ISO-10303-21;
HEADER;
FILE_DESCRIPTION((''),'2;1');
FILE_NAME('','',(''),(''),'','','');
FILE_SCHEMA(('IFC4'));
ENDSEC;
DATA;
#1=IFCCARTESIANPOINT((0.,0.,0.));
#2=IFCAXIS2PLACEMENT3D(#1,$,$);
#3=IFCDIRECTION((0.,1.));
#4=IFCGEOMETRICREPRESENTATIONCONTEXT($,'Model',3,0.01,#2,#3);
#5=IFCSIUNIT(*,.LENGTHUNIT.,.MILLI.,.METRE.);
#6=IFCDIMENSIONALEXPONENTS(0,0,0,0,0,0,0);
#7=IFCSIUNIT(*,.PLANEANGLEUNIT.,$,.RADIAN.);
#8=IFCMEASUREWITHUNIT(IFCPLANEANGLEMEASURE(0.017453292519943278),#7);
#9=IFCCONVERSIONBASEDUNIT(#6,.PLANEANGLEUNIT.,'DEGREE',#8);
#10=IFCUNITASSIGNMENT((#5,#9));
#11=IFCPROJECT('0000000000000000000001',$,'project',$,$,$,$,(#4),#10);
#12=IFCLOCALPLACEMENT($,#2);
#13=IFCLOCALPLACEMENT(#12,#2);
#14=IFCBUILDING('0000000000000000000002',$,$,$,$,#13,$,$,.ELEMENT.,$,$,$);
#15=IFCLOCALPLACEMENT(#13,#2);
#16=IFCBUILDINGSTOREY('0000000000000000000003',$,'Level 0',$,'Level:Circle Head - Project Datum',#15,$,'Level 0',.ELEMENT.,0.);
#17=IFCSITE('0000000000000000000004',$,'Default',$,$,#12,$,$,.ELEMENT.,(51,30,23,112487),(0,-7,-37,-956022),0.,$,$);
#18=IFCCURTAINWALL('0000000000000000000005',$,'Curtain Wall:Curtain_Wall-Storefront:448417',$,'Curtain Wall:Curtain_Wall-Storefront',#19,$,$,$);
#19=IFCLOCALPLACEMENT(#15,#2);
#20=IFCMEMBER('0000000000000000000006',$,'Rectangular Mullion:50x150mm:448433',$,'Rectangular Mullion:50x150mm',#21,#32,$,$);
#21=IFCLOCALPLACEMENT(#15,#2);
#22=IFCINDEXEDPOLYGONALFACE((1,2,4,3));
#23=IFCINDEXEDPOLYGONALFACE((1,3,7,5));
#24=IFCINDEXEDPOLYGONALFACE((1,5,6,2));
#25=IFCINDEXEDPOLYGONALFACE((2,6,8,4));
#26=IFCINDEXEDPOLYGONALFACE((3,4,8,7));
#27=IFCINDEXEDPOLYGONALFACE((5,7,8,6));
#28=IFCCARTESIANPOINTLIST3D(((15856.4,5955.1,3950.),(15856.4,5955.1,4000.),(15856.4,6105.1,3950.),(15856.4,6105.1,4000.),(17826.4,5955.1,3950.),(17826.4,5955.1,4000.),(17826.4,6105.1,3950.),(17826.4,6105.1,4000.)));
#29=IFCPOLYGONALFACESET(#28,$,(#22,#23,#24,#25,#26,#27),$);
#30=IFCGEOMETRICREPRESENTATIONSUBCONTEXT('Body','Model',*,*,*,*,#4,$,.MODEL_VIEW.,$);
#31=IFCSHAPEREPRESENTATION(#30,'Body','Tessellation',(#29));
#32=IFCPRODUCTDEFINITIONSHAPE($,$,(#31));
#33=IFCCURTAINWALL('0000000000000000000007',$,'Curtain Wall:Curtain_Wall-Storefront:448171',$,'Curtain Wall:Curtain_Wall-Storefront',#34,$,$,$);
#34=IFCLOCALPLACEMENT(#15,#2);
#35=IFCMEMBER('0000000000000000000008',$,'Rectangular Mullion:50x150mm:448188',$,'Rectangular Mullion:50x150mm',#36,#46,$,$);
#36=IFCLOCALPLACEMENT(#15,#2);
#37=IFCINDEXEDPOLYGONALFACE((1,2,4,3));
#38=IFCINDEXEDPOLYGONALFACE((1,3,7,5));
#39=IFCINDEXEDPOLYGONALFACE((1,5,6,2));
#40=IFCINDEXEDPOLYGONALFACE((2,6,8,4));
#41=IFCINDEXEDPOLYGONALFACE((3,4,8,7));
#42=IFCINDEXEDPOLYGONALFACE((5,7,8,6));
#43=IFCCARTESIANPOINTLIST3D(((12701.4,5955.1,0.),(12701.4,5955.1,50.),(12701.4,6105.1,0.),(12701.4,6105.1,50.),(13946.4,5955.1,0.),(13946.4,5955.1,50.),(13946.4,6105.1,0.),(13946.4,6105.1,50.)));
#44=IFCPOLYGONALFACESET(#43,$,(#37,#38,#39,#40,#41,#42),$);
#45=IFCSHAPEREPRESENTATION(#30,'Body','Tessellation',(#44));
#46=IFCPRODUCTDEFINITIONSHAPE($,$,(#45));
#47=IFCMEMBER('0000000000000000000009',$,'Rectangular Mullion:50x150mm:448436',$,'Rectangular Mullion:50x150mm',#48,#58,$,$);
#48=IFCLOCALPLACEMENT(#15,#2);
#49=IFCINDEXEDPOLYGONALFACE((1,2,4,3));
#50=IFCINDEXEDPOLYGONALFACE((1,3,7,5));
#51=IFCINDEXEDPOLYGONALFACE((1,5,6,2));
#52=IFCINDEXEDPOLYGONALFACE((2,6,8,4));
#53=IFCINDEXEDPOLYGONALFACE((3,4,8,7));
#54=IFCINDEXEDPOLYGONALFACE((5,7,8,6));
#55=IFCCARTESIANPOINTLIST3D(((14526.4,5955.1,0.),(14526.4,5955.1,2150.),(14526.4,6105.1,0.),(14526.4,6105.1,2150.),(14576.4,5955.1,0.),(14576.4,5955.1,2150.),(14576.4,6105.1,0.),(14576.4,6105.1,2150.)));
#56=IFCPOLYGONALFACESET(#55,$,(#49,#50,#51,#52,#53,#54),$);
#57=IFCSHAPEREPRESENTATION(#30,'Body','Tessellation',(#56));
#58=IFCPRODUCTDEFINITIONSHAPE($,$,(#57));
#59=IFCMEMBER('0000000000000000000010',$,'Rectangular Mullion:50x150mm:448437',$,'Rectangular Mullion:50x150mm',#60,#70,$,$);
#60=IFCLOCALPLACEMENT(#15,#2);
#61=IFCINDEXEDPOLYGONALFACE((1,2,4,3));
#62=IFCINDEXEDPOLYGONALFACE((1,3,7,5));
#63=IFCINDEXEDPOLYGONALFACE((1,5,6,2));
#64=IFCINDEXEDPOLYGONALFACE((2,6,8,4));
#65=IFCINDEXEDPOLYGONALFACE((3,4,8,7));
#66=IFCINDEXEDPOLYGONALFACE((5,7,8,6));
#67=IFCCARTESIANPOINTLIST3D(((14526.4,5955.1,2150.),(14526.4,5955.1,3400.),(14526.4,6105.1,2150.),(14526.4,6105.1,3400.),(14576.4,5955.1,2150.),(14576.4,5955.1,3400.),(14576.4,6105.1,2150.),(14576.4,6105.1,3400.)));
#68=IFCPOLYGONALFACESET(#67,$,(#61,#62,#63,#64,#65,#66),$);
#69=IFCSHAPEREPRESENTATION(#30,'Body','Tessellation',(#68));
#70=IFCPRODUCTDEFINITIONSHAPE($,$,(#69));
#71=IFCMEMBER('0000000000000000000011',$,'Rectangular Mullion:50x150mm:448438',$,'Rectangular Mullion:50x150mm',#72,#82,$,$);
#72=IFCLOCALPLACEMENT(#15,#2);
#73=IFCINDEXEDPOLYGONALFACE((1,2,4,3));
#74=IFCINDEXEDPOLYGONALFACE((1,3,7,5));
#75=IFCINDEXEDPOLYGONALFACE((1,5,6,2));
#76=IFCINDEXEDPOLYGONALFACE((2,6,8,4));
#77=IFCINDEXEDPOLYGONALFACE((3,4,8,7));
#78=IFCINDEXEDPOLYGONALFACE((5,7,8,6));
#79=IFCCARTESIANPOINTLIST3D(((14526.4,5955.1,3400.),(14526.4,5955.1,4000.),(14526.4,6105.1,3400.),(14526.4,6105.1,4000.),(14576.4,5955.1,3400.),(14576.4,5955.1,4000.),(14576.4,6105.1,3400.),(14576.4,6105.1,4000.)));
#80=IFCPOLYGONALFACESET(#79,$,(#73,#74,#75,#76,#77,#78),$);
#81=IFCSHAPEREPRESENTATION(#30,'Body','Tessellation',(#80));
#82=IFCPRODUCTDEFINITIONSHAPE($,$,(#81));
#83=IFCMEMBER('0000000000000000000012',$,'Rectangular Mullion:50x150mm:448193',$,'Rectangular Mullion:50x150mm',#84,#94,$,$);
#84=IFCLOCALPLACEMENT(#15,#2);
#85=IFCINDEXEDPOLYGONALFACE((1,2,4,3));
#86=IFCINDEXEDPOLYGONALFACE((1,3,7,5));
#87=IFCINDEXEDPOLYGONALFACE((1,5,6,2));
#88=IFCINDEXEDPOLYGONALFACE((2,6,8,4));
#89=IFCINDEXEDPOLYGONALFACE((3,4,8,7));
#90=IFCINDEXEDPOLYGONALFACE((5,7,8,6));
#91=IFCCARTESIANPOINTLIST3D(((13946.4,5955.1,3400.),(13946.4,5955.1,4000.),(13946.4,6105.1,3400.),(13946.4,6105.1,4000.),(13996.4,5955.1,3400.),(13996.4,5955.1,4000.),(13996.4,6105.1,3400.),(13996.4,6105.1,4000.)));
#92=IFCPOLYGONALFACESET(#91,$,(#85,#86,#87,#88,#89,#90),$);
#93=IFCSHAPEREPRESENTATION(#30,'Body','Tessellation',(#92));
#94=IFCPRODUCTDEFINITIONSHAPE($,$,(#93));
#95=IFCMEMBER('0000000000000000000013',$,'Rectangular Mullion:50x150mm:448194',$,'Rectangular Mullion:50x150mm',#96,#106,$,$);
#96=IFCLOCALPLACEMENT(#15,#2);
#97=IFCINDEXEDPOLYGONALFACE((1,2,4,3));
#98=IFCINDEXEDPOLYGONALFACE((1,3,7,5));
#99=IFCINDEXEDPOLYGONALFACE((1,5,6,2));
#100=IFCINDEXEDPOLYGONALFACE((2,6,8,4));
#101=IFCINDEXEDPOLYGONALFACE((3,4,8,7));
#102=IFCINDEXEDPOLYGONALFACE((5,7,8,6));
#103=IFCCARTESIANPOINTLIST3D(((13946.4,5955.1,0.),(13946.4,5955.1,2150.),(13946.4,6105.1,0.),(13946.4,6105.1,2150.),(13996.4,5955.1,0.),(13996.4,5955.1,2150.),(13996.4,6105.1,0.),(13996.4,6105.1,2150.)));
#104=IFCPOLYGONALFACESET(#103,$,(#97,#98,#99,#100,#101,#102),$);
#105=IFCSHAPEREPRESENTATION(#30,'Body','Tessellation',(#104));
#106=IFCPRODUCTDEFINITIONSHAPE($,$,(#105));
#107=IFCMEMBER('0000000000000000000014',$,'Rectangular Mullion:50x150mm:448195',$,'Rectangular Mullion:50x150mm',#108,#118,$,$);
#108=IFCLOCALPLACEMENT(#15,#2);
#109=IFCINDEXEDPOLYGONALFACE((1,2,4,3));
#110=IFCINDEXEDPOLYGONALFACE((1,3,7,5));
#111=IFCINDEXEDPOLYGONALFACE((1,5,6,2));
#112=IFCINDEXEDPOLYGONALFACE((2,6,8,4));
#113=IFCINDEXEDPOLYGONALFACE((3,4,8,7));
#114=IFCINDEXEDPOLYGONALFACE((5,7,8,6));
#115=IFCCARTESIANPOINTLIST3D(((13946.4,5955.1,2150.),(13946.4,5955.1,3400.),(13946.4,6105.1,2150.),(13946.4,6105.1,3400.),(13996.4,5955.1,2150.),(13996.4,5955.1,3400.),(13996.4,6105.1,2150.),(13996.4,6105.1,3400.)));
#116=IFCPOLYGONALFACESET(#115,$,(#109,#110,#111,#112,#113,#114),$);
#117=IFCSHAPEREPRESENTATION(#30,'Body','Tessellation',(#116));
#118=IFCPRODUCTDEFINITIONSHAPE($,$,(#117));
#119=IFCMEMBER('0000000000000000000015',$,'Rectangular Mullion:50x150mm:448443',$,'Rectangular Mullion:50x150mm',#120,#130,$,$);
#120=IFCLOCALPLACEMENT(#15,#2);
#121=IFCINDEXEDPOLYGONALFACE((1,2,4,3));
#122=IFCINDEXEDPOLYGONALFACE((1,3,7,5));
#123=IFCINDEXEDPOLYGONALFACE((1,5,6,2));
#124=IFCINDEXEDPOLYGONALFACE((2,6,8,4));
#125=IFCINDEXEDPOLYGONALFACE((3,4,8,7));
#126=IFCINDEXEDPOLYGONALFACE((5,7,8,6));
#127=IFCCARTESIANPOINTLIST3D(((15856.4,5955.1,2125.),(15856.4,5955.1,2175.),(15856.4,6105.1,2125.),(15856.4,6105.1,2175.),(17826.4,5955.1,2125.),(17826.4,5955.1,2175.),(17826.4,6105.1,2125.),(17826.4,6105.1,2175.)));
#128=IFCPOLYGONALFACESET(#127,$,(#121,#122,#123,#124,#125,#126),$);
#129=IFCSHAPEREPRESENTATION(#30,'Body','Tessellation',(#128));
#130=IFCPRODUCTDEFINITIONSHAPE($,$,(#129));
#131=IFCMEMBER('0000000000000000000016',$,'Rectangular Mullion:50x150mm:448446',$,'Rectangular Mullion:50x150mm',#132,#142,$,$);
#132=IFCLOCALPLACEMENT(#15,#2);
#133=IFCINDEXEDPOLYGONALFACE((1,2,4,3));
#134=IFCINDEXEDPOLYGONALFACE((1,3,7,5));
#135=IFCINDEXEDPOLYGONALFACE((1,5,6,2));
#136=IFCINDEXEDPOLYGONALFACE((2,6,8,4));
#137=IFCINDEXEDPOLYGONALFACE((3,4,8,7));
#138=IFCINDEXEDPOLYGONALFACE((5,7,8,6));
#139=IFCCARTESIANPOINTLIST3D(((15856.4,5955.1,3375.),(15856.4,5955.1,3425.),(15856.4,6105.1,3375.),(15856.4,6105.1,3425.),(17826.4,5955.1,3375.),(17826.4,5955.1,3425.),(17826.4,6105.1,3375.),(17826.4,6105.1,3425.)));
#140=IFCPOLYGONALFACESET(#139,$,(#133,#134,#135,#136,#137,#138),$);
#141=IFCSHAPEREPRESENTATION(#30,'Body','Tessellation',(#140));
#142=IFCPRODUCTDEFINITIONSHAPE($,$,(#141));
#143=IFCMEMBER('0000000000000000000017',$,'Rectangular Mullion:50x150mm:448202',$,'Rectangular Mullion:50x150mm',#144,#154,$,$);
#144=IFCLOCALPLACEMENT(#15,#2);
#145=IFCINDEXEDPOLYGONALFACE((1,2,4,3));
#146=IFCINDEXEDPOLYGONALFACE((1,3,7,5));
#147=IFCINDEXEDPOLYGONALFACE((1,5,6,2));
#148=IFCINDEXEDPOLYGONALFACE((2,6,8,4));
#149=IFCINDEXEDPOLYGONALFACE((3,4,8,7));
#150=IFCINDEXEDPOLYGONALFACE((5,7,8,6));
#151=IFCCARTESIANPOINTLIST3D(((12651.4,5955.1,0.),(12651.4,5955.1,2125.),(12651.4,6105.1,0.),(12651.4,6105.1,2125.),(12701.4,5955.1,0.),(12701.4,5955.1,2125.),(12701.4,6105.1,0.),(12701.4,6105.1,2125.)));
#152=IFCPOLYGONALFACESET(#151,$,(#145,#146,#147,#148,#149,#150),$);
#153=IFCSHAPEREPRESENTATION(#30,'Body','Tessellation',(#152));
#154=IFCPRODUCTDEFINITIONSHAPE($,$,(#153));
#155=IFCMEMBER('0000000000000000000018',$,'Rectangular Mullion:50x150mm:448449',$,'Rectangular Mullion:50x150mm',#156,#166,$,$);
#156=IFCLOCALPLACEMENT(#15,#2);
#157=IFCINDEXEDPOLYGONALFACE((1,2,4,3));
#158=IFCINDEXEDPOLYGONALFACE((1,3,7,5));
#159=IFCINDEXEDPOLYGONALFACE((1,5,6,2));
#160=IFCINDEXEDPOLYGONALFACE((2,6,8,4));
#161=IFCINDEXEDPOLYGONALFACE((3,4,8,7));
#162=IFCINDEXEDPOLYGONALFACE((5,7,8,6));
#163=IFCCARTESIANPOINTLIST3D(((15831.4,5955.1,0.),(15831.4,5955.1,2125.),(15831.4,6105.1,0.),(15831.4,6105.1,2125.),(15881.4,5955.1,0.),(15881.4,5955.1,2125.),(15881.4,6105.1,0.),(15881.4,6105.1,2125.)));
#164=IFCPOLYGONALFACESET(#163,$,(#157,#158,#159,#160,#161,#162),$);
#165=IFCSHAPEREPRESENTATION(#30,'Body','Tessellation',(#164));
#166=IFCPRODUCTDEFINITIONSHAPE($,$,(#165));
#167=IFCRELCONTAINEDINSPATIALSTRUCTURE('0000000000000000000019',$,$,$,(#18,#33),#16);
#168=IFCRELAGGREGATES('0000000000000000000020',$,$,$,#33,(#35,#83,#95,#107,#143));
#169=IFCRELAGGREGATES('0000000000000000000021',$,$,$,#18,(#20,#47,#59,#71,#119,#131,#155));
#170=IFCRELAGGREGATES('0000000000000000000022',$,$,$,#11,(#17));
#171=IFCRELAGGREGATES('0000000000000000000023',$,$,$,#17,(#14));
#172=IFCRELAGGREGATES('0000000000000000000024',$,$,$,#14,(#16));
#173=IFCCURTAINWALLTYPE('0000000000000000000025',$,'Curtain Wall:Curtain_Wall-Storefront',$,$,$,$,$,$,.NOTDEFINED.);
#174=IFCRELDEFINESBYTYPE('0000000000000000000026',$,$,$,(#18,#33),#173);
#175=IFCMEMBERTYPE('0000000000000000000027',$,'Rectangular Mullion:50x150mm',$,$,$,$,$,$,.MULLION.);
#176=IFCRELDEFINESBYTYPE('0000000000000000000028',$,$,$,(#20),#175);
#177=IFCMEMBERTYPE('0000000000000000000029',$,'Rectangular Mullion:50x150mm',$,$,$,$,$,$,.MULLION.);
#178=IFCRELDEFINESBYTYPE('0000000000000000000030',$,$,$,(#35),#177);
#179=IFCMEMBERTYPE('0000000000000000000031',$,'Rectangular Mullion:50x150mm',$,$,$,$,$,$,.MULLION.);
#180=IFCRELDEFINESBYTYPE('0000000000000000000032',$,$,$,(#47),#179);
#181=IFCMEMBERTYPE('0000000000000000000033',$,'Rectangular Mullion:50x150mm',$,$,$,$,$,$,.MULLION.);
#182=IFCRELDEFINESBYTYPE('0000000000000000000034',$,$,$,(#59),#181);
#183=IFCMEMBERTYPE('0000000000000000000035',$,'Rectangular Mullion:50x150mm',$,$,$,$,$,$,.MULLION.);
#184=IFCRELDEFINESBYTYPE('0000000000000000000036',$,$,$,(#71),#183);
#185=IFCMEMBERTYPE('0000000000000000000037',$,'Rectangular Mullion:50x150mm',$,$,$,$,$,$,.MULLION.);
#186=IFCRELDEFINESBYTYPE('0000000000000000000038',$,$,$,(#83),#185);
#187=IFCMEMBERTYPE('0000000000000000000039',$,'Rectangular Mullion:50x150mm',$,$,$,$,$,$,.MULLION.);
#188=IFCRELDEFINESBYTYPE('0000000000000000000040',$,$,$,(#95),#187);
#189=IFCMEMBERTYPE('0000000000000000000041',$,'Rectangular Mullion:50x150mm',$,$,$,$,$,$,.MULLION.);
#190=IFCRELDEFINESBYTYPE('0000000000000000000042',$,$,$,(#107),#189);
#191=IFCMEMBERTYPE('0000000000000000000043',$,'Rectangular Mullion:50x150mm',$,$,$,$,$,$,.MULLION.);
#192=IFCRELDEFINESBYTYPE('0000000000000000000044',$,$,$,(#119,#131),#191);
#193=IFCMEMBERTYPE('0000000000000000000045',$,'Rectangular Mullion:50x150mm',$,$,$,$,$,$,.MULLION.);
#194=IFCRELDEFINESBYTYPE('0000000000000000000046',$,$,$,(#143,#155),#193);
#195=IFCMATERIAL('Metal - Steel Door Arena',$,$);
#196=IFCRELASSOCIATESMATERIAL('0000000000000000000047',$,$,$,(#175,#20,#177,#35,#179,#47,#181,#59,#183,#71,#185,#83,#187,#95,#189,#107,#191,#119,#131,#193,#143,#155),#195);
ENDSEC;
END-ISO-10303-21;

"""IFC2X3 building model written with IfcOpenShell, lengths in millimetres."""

from ifc_helpers import new_model, entity, si_unit, converted_unit, direction, frame, origin, origin_2d_with_axis, place, context, subcontext, project, spatial, rectangle, extrude, source, transform, mapped, material, type_object, type_shapes, element, aggregate, save


model = new_model("IFC2X3")

# Units and contexts
model_context = context("Model", 3, precision=0.01, world=origin(), true_north=direction((0.0, 1.0)))
body_context = subcontext(model_context, "Body", "Model", "MODEL_VIEW")
ifc_project = project(units=[si_unit("LENGTHUNIT", "METRE", prefix="MILLI"), converted_unit("PLANEANGLEUNIT", "DEGREE", entity("IfcPlaneAngleMeasure", 0.017453292519943278), si_unit("PLANEANGLEUNIT", "RADIAN"), dimensions=[0, 0, 0, 0, 0, 0, 0])], contexts=[model_context])

# Site, building, storey
site_placement = place(None, origin())
site = spatial("IfcSite", under=ifc_project, at=site_placement, Name="Default", CompositionType="ELEMENT", RefLatitude=(51, 30, 23, 112487), RefLongitude=(0, -7, -37, -956022), RefElevation=0.0)
building_placement = place(site_placement, origin())
building = spatial("IfcBuilding", under=site, at=building_placement, CompositionType="ELEMENT")
storey_placement = place(building_placement, origin())
storey = spatial("IfcBuildingStorey", under=building, at=storey_placement, Name="Level 0", ObjectType="Level:Circle Head - Project Datum", LongName="Level 0", CompositionType="ELEMENT", Elevation=0.0)

# Curtain walls, members
curtain_wall_type = type_object("IfcCurtainWallType", Name="Curtain Wall:Curtain_Wall-Storefront", PredefinedType="NOTDEFINED")
curtain_wall_1_placement = place(storey_placement, origin())
curtain_wall_1 = element("IfcCurtainWall", 1, at=curtain_wall_1_placement, inside=storey, type_object=curtain_wall_type, Name="Curtain Wall:Curtain_Wall-Storefront:448417", ObjectType="Curtain Wall:Curtain_Wall-Storefront")
ifc_material_1 = material(Name="Metal - Steel Door Arena")
member_type_1 = type_object("IfcMemberType", Name="Rectangular Mullion:50x150mm", PredefinedType="MULLION", material=ifc_material_1)
shared_shape_1 = source(origin(), body_context, "Body", "SweptSolid", [
    extrude(rectangle(XDim=50.0, YDim=150.0, at=origin_2d_with_axis()), frame((-25.0, 0.0, -1970.0), z_axis=(0.0, 0.0, 1.0), x_axis=(-1.0, 0.0, 0.0)), (0.0, 0.0, 1.0), 1970.0),
])
type_shapes(member_type_1, [shared_shape_1])
member_1_placement = place(curtain_wall_1_placement, frame((15856.4, 6030.1, 4000.0), z_axis=(-1.0, 0.0, 0.0), x_axis=(0.0, 0.0, 1.0)))
member_1 = element("IfcMember", 2, at=member_1_placement, type_object=member_type_1, material=ifc_material_1, Name="Rectangular Mullion:50x150mm:448433", ObjectType="Rectangular Mullion:50x150mm", context=body_context, shape_type="MappedRepresentation", body=[
    mapped(shared_shape_1, transform((0.0, 0.0, 0.0), scale=1.0)),
])
curtain_wall_2_placement = place(storey_placement, origin())
curtain_wall_2 = element("IfcCurtainWall", 3, at=curtain_wall_2_placement, inside=storey, type_object=curtain_wall_type, Name="Curtain Wall:Curtain_Wall-Storefront:448171", ObjectType="Curtain Wall:Curtain_Wall-Storefront")
member_type_2 = type_object("IfcMemberType", Name="Rectangular Mullion:50x150mm", PredefinedType="MULLION", material=ifc_material_1)
shared_shape_2 = source(origin(), body_context, "Body", "SweptSolid", [
    extrude(rectangle(XDim=50.0, YDim=150.0, at=origin_2d_with_axis()), frame((-25.0, 0.0, -1245.0), z_axis=(0.0, 0.0, 1.0), x_axis=(-1.0, 0.0, 0.0)), (0.0, 0.0, 1.0), 1245.0),
])
type_shapes(member_type_2, [shared_shape_2])
member_2_placement = place(curtain_wall_2_placement, frame((13946.4, 6030.1, 0.0), z_axis=(1.0, 0.0, 0.0), x_axis=(0.0, 0.0, -1.0)))
member_2 = element("IfcMember", 4, at=member_2_placement, type_object=member_type_2, material=ifc_material_1, Name="Rectangular Mullion:50x150mm:448188", ObjectType="Rectangular Mullion:50x150mm", context=body_context, shape_type="MappedRepresentation", body=[
    mapped(shared_shape_2, transform((0.0, 0.0, 0.0), scale=1.0)),
])

# Members
member_type_3 = type_object("IfcMemberType", Name="Rectangular Mullion:50x150mm", PredefinedType="MULLION", material=ifc_material_1)
shared_shape_3 = source(origin(), body_context, "Body", "SweptSolid", [
    extrude(rectangle(XDim=50.0, YDim=150.0, at=origin_2d_with_axis()), frame((-25.0, 0.0, -2150.0), z_axis=(0.0, 0.0, 1.0), x_axis=(-1.0, 0.0, 0.0)), (0.0, 0.0, 1.0), 2150.0),
])
type_shapes(member_type_3, [shared_shape_3])
member_3_placement = place(curtain_wall_1_placement, frame((14526.4, 6030.1, 0.0), z_axis=(0.0, 0.0, -1.0), x_axis=(-1.0, 0.0, 0.0)))
member_3 = element("IfcMember", 5, at=member_3_placement, type_object=member_type_3, material=ifc_material_1, Name="Rectangular Mullion:50x150mm:448436", ObjectType="Rectangular Mullion:50x150mm", context=body_context, shape_type="MappedRepresentation", body=[
    mapped(shared_shape_3, transform((0.0, 0.0, 0.0), scale=1.0)),
])
member_type_4 = type_object("IfcMemberType", Name="Rectangular Mullion:50x150mm", PredefinedType="MULLION", material=ifc_material_1)
shared_shape_4 = source(origin(), body_context, "Body", "SweptSolid", [
    extrude(rectangle(XDim=50.0, YDim=150.0, at=origin_2d_with_axis()), frame((-25.0, 0.0, -1250.0), z_axis=(0.0, 0.0, 1.0), x_axis=(-1.0, 0.0, 0.0)), (0.0, 0.0, 1.0), 1250.0),
])
type_shapes(member_type_4, [shared_shape_4])
member_4_placement = place(curtain_wall_1_placement, frame((14526.4, 6030.1, 2150.0), z_axis=(0.0, 0.0, -1.0), x_axis=(-1.0, 0.0, 0.0)))
member_4 = element("IfcMember", 6, at=member_4_placement, type_object=member_type_4, material=ifc_material_1, Name="Rectangular Mullion:50x150mm:448437", ObjectType="Rectangular Mullion:50x150mm", context=body_context, shape_type="MappedRepresentation", body=[
    mapped(shared_shape_4, transform((0.0, 0.0, 0.0), scale=1.0)),
])
member_type_5 = type_object("IfcMemberType", Name="Rectangular Mullion:50x150mm", PredefinedType="MULLION", material=ifc_material_1)
shared_shape_5 = source(origin(), body_context, "Body", "SweptSolid", [
    extrude(rectangle(XDim=50.0, YDim=150.0, at=origin_2d_with_axis()), frame((-25.0, 0.0, -600.0), z_axis=(0.0, 0.0, 1.0), x_axis=(-1.0, 0.0, 0.0)), (0.0, 0.0, 1.0), 600.0),
])
type_shapes(member_type_5, [shared_shape_5])
member_5_placement = place(curtain_wall_1_placement, frame((14526.4, 6030.1, 3400.0), z_axis=(0.0, 0.0, -1.0), x_axis=(-1.0, 0.0, 0.0)))
member_5 = element("IfcMember", 7, at=member_5_placement, type_object=member_type_5, material=ifc_material_1, Name="Rectangular Mullion:50x150mm:448438", ObjectType="Rectangular Mullion:50x150mm", context=body_context, shape_type="MappedRepresentation", body=[
    mapped(shared_shape_5, transform((0.0, 0.0, 0.0), scale=1.0)),
])
member_type_6 = type_object("IfcMemberType", Name="Rectangular Mullion:50x150mm", PredefinedType="MULLION", material=ifc_material_1)
shared_shape_6 = source(origin(), body_context, "Body", "SweptSolid", [
    extrude(rectangle(XDim=50.0, YDim=150.0, at=origin_2d_with_axis()), frame((-25.0, 0.0, -600.0), z_axis=(0.0, 0.0, 1.0), x_axis=(-1.0, 0.0, 0.0)), (0.0, 0.0, 1.0), 600.0),
])
type_shapes(member_type_6, [shared_shape_6])
member_6_placement = place(curtain_wall_2_placement, frame((13996.4, 6030.1, 4000.0)))
member_6 = element("IfcMember", 8, at=member_6_placement, type_object=member_type_6, material=ifc_material_1, Name="Rectangular Mullion:50x150mm:448193", ObjectType="Rectangular Mullion:50x150mm", context=body_context, shape_type="MappedRepresentation", body=[
    mapped(shared_shape_6, transform((0.0, 0.0, 0.0), scale=1.0)),
])
member_type_7 = type_object("IfcMemberType", Name="Rectangular Mullion:50x150mm", PredefinedType="MULLION", material=ifc_material_1)
shared_shape_7 = source(origin(), body_context, "Body", "SweptSolid", [
    extrude(rectangle(XDim=50.0, YDim=150.0, at=origin_2d_with_axis()), frame((-25.0, 0.0, -2150.0), z_axis=(0.0, 0.0, 1.0), x_axis=(-1.0, 0.0, 0.0)), (0.0, 0.0, 1.0), 2150.0),
])
type_shapes(member_type_7, [shared_shape_7])
member_7_placement = place(curtain_wall_2_placement, frame((13996.4, 6030.1, 2150.0)))
member_7 = element("IfcMember", 9, at=member_7_placement, type_object=member_type_7, material=ifc_material_1, Name="Rectangular Mullion:50x150mm:448194", ObjectType="Rectangular Mullion:50x150mm", context=body_context, shape_type="MappedRepresentation", body=[
    mapped(shared_shape_7, transform((0.0, 0.0, 0.0), scale=1.0)),
])
member_type_8 = type_object("IfcMemberType", Name="Rectangular Mullion:50x150mm", PredefinedType="MULLION", material=ifc_material_1)
shared_shape_8 = source(origin(), body_context, "Body", "SweptSolid", [
    extrude(rectangle(XDim=50.0, YDim=150.0, at=origin_2d_with_axis()), frame((-25.0, 0.0, -1250.0), z_axis=(0.0, 0.0, 1.0), x_axis=(-1.0, 0.0, 0.0)), (0.0, 0.0, 1.0), 1250.0),
])
type_shapes(member_type_8, [shared_shape_8])
member_8_placement = place(curtain_wall_2_placement, frame((13996.4, 6030.1, 3400.0)))
member_8 = element("IfcMember", 10, at=member_8_placement, type_object=member_type_8, material=ifc_material_1, Name="Rectangular Mullion:50x150mm:448195", ObjectType="Rectangular Mullion:50x150mm", context=body_context, shape_type="MappedRepresentation", body=[
    mapped(shared_shape_8, transform((0.0, 0.0, 0.0), scale=1.0)),
])
member_type_9 = type_object("IfcMemberType", Name="Rectangular Mullion:50x150mm", PredefinedType="MULLION", material=ifc_material_1)
shared_shape_9 = source(origin(), body_context, "Body", "SweptSolid", [
    extrude(rectangle(XDim=50.0, YDim=150.0, at=origin_2d_with_axis()), frame((0.0, 0.0, -1970.0), z_axis=(0.0, 0.0, 1.0), x_axis=(-1.0, 0.0, 0.0)), (0.0, 0.0, 1.0), 1970.0),
])
type_shapes(member_type_9, [shared_shape_9])
member_9_placement = place(curtain_wall_1_placement, frame((15856.4, 6030.1, 2150.0), z_axis=(-1.0, 0.0, 0.0), x_axis=(0.0, 0.0, 1.0)))
member_9 = element("IfcMember", 11, at=member_9_placement, type_object=member_type_9, material=ifc_material_1, Name="Rectangular Mullion:50x150mm:448443", ObjectType="Rectangular Mullion:50x150mm", context=body_context, shape_type="MappedRepresentation", body=[
    mapped(shared_shape_9, transform((0.0, 0.0, 0.0), scale=1.0)),
])
member_10_placement = place(curtain_wall_1_placement, frame((15856.4, 6030.1, 3400.0), z_axis=(-1.0, 0.0, 0.0), x_axis=(0.0, 0.0, 1.0)))
member_10 = element("IfcMember", 12, at=member_10_placement, type_object=member_type_9, material=ifc_material_1, Name="Rectangular Mullion:50x150mm:448446", ObjectType="Rectangular Mullion:50x150mm", context=body_context, shape_type="MappedRepresentation", body=[
    mapped(shared_shape_9, transform((0.0, 0.0, 0.0), scale=1.0)),
])
member_type_10 = type_object("IfcMemberType", Name="Rectangular Mullion:50x150mm", PredefinedType="MULLION", material=ifc_material_1)
shared_shape_10 = source(origin(), body_context, "Body", "SweptSolid", [
    extrude(rectangle(XDim=50.0, YDim=150.0, at=origin_2d_with_axis()), frame((0.0, 0.0, -2125.0), z_axis=(0.0, 0.0, 1.0), x_axis=(-1.0, 0.0, 0.0)), (0.0, 0.0, 1.0), 2125.0),
])
type_shapes(member_type_10, [shared_shape_10])
member_11_placement = place(curtain_wall_2_placement, frame((12676.4, 6030.1, 0.0), z_axis=(0.0, 0.0, -1.0), x_axis=(-1.0, 0.0, 0.0)))
member_11 = element("IfcMember", 13, at=member_11_placement, type_object=member_type_10, material=ifc_material_1, Name="Rectangular Mullion:50x150mm:448202", ObjectType="Rectangular Mullion:50x150mm", context=body_context, shape_type="MappedRepresentation", body=[
    mapped(shared_shape_10, transform((0.0, 0.0, 0.0), scale=1.0)),
])
member_12_placement = place(curtain_wall_1_placement, frame((15856.4, 6030.1, 0.0), z_axis=(0.0, 0.0, -1.0), x_axis=(-1.0, 0.0, 0.0)))
member_12 = element("IfcMember", 14, at=member_12_placement, type_object=member_type_10, material=ifc_material_1, Name="Rectangular Mullion:50x150mm:448449", ObjectType="Rectangular Mullion:50x150mm", context=body_context, shape_type="MappedRepresentation", body=[
    mapped(shared_shape_10, transform((0.0, 0.0, 0.0), scale=1.0)),
])

aggregate(curtain_wall_2, [member_2, member_6, member_7, member_8, member_11])
aggregate(curtain_wall_1, [member_1, member_3, member_4, member_5, member_9, member_10, member_12])

save(model, "model.ifc")
